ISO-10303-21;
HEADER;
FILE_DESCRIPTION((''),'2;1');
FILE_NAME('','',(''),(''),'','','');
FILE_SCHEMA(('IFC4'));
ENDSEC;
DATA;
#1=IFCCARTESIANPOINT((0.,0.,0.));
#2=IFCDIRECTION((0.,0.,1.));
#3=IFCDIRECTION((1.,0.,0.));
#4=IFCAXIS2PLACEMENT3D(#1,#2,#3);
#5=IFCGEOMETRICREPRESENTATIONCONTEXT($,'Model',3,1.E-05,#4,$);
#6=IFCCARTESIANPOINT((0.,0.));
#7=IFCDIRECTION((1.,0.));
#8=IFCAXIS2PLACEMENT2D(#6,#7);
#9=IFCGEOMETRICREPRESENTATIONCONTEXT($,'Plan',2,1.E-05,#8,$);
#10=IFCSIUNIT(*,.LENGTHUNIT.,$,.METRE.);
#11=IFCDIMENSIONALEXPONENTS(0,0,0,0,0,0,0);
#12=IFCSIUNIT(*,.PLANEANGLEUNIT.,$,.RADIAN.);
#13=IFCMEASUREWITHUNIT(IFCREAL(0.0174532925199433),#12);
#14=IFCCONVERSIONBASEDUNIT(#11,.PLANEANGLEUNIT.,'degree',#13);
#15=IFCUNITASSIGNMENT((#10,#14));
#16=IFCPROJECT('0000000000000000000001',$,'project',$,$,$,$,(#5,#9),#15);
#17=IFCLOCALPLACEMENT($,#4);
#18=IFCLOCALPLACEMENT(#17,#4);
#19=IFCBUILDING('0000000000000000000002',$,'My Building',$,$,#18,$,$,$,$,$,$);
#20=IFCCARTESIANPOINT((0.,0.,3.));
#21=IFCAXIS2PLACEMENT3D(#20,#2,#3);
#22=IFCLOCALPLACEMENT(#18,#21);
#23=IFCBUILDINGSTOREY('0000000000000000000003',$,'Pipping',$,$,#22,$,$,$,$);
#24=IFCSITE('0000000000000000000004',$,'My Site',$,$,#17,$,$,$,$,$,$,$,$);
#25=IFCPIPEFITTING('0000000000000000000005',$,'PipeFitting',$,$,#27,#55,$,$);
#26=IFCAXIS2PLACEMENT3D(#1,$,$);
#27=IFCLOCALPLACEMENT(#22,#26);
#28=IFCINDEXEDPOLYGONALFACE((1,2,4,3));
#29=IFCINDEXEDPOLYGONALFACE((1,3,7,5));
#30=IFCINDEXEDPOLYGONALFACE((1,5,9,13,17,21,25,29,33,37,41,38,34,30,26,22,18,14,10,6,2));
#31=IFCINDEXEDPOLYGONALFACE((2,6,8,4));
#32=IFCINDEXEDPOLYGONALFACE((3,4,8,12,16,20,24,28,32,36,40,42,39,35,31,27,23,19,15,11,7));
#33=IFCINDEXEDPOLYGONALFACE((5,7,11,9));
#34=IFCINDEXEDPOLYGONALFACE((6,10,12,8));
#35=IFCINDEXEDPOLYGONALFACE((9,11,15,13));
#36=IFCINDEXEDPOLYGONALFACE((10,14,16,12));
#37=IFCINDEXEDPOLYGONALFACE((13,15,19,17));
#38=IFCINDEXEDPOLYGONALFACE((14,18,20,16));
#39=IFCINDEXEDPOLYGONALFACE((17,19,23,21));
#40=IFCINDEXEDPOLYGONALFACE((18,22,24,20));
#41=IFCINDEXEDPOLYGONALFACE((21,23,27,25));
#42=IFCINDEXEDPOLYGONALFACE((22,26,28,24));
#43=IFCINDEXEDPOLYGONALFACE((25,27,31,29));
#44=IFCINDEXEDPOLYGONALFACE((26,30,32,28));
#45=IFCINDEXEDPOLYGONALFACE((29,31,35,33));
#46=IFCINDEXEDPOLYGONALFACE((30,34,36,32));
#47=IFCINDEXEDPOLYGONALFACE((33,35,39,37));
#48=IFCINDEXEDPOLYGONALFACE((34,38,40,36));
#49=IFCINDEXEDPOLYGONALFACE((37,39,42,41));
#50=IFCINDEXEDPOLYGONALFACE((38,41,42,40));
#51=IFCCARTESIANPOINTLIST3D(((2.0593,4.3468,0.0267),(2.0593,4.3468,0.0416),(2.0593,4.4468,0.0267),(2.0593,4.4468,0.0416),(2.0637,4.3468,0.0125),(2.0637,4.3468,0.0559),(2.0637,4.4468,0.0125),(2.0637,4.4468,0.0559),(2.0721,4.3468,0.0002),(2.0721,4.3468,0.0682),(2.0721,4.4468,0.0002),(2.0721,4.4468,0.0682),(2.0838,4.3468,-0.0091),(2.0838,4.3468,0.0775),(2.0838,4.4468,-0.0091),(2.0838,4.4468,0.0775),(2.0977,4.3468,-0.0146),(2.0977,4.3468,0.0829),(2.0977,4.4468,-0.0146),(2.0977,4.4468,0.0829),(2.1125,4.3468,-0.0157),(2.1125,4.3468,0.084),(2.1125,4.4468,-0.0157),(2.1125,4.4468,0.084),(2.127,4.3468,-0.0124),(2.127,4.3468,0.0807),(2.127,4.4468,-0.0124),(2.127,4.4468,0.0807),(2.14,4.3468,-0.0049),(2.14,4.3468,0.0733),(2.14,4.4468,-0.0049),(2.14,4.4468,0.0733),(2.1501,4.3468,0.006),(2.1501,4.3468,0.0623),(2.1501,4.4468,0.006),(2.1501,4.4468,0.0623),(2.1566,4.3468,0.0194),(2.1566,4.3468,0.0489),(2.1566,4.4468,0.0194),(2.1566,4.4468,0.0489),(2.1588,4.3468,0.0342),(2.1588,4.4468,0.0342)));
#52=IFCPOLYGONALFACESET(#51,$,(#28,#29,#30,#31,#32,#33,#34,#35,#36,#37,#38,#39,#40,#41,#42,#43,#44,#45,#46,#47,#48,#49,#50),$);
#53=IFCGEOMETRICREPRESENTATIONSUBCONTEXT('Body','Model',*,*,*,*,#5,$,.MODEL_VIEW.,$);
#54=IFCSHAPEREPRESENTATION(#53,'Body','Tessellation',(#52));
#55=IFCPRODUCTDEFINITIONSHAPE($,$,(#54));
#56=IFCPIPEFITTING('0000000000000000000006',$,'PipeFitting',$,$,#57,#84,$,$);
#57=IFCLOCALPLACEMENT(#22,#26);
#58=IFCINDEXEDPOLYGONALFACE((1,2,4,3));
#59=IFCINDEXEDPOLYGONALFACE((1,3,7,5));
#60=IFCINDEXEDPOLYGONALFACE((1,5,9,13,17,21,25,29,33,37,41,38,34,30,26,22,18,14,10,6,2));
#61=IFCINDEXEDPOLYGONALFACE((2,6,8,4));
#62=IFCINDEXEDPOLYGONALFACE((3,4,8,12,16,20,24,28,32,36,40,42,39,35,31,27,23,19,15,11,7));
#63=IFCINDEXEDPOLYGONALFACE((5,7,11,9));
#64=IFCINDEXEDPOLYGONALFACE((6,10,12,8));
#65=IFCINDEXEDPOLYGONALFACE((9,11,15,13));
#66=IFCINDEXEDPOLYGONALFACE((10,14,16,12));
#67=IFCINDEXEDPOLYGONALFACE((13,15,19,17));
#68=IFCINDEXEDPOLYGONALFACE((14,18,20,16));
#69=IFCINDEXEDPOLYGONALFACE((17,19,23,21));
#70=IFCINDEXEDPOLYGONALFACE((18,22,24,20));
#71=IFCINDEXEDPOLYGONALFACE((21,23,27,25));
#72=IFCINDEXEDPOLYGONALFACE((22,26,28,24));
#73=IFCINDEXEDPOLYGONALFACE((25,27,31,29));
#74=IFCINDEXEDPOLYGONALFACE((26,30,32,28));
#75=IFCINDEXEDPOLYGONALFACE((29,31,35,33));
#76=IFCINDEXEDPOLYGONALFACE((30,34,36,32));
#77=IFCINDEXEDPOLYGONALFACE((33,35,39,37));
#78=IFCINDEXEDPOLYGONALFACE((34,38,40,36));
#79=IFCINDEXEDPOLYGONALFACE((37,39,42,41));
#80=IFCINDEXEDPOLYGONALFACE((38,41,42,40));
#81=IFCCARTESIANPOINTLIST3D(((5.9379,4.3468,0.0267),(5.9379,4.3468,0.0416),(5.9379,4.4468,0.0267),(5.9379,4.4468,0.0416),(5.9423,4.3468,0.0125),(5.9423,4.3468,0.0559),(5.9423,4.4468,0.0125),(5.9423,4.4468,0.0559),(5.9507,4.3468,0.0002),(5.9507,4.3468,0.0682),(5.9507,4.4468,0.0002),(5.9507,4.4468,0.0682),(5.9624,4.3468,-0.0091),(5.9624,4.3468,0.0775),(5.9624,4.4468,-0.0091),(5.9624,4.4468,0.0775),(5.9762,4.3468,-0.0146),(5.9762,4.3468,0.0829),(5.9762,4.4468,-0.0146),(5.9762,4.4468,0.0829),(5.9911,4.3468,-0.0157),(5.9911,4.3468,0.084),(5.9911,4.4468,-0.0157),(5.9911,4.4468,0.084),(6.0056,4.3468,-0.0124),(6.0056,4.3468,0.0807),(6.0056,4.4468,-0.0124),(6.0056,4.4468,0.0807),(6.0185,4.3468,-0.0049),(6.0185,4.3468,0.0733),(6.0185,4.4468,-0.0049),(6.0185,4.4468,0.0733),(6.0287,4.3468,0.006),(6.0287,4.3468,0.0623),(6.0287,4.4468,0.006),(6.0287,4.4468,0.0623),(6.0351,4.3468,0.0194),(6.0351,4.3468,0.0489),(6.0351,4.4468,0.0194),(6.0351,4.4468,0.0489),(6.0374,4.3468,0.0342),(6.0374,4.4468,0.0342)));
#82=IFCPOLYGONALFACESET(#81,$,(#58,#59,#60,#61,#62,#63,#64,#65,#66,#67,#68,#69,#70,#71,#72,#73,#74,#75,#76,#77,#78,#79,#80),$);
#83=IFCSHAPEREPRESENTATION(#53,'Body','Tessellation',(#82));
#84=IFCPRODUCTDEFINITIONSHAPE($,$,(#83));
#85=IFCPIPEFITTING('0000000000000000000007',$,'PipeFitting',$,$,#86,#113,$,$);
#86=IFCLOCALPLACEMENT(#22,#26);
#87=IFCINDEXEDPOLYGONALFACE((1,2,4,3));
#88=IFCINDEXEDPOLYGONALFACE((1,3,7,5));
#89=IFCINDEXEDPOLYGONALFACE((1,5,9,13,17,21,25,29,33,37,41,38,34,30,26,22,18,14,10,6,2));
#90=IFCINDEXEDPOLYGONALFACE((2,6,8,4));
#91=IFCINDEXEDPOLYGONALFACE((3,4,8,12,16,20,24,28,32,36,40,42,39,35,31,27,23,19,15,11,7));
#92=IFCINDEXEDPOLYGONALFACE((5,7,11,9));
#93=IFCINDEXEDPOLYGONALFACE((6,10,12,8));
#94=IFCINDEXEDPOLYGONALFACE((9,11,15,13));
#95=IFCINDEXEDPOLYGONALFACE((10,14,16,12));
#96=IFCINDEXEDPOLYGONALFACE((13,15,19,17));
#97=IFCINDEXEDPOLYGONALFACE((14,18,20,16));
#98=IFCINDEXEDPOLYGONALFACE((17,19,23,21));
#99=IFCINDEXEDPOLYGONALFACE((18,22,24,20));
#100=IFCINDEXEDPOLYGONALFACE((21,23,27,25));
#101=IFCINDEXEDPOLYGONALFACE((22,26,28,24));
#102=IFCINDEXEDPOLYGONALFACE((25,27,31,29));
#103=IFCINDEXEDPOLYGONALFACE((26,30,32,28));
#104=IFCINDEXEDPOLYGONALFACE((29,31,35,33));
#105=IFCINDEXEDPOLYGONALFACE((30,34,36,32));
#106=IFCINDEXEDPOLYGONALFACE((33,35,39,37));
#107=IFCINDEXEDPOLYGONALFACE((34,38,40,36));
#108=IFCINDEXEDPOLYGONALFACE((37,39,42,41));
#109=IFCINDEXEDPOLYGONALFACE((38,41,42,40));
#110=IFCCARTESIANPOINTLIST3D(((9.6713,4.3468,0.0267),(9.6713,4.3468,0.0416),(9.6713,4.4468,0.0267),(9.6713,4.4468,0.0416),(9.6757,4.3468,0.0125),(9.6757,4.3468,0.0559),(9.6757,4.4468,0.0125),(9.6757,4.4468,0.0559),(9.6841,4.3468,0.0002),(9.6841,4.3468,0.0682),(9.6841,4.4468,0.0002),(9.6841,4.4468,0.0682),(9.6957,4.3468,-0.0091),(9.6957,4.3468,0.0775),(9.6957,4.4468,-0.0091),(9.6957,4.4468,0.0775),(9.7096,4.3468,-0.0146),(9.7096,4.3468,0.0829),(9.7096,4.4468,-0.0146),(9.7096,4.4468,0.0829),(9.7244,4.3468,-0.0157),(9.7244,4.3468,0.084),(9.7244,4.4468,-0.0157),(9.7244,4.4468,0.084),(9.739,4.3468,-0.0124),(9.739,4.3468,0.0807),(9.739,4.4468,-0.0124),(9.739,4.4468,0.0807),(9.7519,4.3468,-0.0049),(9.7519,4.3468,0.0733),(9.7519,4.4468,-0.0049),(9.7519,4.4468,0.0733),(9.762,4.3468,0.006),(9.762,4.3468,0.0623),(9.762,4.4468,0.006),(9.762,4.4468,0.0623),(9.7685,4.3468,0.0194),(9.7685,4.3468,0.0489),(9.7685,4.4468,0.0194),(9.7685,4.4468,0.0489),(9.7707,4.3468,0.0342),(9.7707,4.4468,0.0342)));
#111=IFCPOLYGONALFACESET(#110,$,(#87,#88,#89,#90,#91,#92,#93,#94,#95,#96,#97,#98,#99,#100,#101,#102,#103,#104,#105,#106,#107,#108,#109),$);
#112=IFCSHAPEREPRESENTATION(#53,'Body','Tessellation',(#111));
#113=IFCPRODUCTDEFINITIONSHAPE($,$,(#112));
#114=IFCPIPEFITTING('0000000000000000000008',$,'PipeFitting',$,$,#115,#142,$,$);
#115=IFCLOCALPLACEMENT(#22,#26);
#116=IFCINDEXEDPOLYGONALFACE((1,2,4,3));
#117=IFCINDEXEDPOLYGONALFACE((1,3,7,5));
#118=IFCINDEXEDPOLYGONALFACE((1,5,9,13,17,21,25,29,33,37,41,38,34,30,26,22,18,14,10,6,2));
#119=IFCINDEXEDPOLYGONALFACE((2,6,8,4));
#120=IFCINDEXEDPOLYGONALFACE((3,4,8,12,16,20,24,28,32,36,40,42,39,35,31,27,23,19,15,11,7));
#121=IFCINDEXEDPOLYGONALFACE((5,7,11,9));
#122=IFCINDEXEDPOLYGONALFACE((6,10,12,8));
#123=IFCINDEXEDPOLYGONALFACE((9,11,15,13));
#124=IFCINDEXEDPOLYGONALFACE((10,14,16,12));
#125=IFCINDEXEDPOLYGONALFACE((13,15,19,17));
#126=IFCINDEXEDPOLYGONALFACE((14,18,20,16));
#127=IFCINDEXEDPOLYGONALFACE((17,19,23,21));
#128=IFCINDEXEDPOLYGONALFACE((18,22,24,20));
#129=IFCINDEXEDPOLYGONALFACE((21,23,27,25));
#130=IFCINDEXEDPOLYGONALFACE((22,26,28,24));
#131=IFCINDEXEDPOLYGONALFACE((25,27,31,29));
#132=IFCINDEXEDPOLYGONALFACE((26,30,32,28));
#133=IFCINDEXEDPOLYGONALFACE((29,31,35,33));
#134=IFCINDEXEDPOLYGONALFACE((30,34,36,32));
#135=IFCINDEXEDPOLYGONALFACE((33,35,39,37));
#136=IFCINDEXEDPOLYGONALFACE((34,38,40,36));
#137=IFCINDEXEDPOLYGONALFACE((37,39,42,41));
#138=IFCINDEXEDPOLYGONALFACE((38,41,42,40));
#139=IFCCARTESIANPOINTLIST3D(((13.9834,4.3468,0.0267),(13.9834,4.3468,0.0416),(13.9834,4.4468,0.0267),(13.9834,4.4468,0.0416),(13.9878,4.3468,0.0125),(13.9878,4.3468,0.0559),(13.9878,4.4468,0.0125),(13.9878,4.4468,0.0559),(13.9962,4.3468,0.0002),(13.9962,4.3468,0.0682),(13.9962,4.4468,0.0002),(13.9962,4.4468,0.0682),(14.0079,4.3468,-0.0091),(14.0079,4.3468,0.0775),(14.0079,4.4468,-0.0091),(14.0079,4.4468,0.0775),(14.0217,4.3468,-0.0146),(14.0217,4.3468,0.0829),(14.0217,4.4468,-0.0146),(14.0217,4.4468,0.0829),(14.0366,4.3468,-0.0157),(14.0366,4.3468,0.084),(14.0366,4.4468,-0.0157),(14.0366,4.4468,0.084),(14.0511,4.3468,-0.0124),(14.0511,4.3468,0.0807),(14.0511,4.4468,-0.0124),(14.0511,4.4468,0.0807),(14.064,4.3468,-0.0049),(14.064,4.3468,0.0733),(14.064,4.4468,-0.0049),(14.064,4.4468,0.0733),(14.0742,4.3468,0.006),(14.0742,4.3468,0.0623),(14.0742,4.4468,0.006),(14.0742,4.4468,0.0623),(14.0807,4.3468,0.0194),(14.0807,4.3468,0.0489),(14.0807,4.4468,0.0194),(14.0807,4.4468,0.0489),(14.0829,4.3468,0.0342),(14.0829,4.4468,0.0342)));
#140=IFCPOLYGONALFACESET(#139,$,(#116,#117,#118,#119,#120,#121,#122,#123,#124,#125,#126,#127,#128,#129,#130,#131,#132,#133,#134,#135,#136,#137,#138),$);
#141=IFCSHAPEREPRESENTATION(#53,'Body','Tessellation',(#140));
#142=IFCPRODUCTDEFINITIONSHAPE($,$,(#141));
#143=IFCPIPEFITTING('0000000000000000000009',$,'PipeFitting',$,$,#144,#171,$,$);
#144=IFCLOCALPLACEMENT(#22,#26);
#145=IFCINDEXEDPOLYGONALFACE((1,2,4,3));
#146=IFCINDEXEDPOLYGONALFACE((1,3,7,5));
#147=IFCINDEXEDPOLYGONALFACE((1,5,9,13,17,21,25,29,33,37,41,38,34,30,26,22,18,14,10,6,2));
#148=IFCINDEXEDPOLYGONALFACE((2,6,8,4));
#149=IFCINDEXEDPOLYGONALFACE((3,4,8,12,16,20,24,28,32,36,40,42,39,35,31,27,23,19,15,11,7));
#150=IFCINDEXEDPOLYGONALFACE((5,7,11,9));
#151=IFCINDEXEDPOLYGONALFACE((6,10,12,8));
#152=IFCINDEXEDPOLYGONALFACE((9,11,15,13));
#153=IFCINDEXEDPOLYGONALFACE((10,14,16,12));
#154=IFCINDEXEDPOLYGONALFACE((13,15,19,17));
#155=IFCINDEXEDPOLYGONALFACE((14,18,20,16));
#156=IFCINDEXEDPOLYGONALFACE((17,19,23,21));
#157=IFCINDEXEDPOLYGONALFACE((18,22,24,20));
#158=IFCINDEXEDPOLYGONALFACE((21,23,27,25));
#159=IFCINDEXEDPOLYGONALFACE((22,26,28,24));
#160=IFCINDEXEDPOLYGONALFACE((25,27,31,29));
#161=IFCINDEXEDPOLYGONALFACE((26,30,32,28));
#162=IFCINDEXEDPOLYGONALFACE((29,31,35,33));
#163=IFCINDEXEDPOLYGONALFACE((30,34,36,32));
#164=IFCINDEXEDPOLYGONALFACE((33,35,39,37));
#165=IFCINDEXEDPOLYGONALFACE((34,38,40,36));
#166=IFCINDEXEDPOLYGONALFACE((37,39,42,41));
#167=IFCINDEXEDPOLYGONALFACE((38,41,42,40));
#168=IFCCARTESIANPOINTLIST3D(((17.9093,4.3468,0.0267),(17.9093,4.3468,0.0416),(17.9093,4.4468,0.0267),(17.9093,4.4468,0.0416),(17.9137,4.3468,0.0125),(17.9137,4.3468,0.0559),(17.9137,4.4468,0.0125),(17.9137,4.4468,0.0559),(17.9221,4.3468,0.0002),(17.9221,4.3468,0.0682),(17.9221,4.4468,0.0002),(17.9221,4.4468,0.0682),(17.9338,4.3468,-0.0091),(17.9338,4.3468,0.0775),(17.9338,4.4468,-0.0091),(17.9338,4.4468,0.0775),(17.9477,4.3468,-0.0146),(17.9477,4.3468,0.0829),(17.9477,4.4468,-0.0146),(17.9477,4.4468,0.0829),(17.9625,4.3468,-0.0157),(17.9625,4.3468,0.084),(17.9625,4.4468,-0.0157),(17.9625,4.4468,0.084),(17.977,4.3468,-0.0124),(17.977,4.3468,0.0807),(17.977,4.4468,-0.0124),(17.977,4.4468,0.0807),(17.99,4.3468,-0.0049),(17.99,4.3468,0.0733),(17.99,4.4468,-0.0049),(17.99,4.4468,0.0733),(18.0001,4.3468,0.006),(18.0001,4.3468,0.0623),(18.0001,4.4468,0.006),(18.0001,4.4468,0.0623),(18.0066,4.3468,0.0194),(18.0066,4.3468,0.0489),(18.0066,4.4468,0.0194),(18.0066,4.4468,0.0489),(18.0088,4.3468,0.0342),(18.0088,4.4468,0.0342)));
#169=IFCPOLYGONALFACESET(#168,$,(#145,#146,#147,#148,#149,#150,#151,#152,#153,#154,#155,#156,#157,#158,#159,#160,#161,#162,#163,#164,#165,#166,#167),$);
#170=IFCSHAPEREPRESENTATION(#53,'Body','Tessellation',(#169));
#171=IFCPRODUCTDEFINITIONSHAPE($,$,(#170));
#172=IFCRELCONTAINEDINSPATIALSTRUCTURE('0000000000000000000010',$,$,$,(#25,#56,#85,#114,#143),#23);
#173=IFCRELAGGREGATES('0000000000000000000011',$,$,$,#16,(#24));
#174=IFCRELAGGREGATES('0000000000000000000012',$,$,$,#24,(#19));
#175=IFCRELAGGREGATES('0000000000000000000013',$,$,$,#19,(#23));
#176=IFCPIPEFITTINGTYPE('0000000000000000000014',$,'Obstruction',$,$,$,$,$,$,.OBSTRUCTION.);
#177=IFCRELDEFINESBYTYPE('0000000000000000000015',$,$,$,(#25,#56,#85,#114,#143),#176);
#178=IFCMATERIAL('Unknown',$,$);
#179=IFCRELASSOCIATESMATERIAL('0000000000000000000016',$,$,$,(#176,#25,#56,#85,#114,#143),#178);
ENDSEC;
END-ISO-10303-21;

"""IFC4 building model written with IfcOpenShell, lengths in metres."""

from ifc_helpers import new_model, entity, si_unit, converted_unit, frame, origin_with_axes, origin_2d_with_axis, place, context, subcontext, project, spatial, circle, extrude, material, material_profile, profile_set, profile_usage, type_object, element, save


model = new_model("IFC4")

# Units and contexts
model_context = context("Model", 3, precision=1e-05, world=origin_with_axes())
plan_context = context("Plan", 2, precision=1e-05, world=origin_2d_with_axis())
body_context = subcontext(model_context, "Body", "Model", "MODEL_VIEW")
ifc_project = project(units=[si_unit("LENGTHUNIT", "METRE"), converted_unit("PLANEANGLEUNIT", "degree", entity("IfcReal", 0.0174532925199433), si_unit("PLANEANGLEUNIT", "RADIAN"), dimensions=[0, 0, 0, 0, 0, 0, 0])], contexts=[model_context, plan_context])

# Site, building, storey
site_placement = place(None, origin_with_axes())
site = spatial("IfcSite", under=ifc_project, at=site_placement, Name="My Site")
building_placement = place(site_placement, origin_with_axes())
building = spatial("IfcBuilding", under=site, at=building_placement, Name="My Building")
storey_placement = place(building_placement, frame((0.0, 0.0, 3.0), z_axis=(0.0, 0.0, 1.0), x_axis=(1.0, 0.0, 0.0)))
storey = spatial("IfcBuildingStorey", under=building, at=storey_placement, Name="Pipping")

# Shared definitions
ifc_material = material(Name="Unknown")

# Pipe fittings
ifc_material_profile_1 = material_profile(ifc_material, circle(Radius=0.05))
ifc_profile_set_1 = profile_set([ifc_material_profile_1])
ifc_profile_usage_1 = profile_usage(ifc_profile_set_1, cardinal=5)
pipe_fitting_type_1 = type_object("IfcPipeFittingType", Name="Obstruction", PredefinedType="OBSTRUCTION", material=ifc_profile_set_1)
pipe_fitting_1_placement = place(storey_placement, frame((2.1088, 4.3468, 0.0342), z_axis=(0.0, 1.0, 0.000073), x_axis=(1.0, 0.0, 0.0)))
element("IfcPipeFitting", 1, at=pipe_fitting_1_placement, inside=storey, type_object=pipe_fitting_type_1, material=ifc_profile_usage_1, Name="PipeFitting", context=body_context, shape_type="SweptSolid", body=[
    extrude(circle(Radius=0.05), origin_with_axes(), (0.0, 0.0, 1.0), 0.1),
])
ifc_profile_usage_2 = profile_usage(ifc_profile_set_1, cardinal=5)
pipe_fitting_2_placement = place(storey_placement, frame((5.9874, 4.3468, 0.0342), z_axis=(0.0, 1.0, 0.000073), x_axis=(1.0, 0.0, 0.0)))
element("IfcPipeFitting", 2, at=pipe_fitting_2_placement, inside=storey, type_object=pipe_fitting_type_1, material=ifc_profile_usage_2, Name="PipeFitting", context=body_context, shape_type="SweptSolid", body=[
    extrude(circle(Radius=0.05), origin_with_axes(), (0.0, 0.0, 1.0), 0.1),
])
ifc_profile_usage_3 = profile_usage(ifc_profile_set_1, cardinal=5)
pipe_fitting_3_placement = place(storey_placement, frame((9.7207, 4.3468, 0.0342), z_axis=(0.0, 1.0, 0.000073), x_axis=(1.0, 0.0, 0.0)))
element("IfcPipeFitting", 3, at=pipe_fitting_3_placement, inside=storey, type_object=pipe_fitting_type_1, material=ifc_profile_usage_3, Name="PipeFitting", context=body_context, shape_type="SweptSolid", body=[
    extrude(circle(Radius=0.05), origin_with_axes(), (0.0, 0.0, 1.0), 0.1),
])
ifc_profile_usage_4 = profile_usage(ifc_profile_set_1, cardinal=5)
pipe_fitting_4_placement = place(storey_placement, frame((14.0329, 4.3468, 0.0342), z_axis=(0.0, 1.0, 0.000073), x_axis=(1.0, 0.0, 0.0)))
element("IfcPipeFitting", 4, at=pipe_fitting_4_placement, inside=storey, type_object=pipe_fitting_type_1, material=ifc_profile_usage_4, Name="PipeFitting", context=body_context, shape_type="SweptSolid", body=[
    extrude(circle(Radius=0.05), origin_with_axes(), (0.0, 0.0, 1.0), 0.1),
])
ifc_profile_usage_5 = profile_usage(ifc_profile_set_1, cardinal=5)
pipe_fitting_5_placement = place(storey_placement, frame((17.9588, 4.3468, 0.0342), z_axis=(0.0, 1.0, 0.000073), x_axis=(1.0, 0.0, 0.0)))
element("IfcPipeFitting", 5, at=pipe_fitting_5_placement, inside=storey, type_object=pipe_fitting_type_1, material=ifc_profile_usage_5, Name="PipeFitting", context=body_context, shape_type="SweptSolid", body=[
    extrude(circle(Radius=0.05), origin_with_axes(), (0.0, 0.0, 1.0), 0.1),
])

save(model, "model.ifc")
